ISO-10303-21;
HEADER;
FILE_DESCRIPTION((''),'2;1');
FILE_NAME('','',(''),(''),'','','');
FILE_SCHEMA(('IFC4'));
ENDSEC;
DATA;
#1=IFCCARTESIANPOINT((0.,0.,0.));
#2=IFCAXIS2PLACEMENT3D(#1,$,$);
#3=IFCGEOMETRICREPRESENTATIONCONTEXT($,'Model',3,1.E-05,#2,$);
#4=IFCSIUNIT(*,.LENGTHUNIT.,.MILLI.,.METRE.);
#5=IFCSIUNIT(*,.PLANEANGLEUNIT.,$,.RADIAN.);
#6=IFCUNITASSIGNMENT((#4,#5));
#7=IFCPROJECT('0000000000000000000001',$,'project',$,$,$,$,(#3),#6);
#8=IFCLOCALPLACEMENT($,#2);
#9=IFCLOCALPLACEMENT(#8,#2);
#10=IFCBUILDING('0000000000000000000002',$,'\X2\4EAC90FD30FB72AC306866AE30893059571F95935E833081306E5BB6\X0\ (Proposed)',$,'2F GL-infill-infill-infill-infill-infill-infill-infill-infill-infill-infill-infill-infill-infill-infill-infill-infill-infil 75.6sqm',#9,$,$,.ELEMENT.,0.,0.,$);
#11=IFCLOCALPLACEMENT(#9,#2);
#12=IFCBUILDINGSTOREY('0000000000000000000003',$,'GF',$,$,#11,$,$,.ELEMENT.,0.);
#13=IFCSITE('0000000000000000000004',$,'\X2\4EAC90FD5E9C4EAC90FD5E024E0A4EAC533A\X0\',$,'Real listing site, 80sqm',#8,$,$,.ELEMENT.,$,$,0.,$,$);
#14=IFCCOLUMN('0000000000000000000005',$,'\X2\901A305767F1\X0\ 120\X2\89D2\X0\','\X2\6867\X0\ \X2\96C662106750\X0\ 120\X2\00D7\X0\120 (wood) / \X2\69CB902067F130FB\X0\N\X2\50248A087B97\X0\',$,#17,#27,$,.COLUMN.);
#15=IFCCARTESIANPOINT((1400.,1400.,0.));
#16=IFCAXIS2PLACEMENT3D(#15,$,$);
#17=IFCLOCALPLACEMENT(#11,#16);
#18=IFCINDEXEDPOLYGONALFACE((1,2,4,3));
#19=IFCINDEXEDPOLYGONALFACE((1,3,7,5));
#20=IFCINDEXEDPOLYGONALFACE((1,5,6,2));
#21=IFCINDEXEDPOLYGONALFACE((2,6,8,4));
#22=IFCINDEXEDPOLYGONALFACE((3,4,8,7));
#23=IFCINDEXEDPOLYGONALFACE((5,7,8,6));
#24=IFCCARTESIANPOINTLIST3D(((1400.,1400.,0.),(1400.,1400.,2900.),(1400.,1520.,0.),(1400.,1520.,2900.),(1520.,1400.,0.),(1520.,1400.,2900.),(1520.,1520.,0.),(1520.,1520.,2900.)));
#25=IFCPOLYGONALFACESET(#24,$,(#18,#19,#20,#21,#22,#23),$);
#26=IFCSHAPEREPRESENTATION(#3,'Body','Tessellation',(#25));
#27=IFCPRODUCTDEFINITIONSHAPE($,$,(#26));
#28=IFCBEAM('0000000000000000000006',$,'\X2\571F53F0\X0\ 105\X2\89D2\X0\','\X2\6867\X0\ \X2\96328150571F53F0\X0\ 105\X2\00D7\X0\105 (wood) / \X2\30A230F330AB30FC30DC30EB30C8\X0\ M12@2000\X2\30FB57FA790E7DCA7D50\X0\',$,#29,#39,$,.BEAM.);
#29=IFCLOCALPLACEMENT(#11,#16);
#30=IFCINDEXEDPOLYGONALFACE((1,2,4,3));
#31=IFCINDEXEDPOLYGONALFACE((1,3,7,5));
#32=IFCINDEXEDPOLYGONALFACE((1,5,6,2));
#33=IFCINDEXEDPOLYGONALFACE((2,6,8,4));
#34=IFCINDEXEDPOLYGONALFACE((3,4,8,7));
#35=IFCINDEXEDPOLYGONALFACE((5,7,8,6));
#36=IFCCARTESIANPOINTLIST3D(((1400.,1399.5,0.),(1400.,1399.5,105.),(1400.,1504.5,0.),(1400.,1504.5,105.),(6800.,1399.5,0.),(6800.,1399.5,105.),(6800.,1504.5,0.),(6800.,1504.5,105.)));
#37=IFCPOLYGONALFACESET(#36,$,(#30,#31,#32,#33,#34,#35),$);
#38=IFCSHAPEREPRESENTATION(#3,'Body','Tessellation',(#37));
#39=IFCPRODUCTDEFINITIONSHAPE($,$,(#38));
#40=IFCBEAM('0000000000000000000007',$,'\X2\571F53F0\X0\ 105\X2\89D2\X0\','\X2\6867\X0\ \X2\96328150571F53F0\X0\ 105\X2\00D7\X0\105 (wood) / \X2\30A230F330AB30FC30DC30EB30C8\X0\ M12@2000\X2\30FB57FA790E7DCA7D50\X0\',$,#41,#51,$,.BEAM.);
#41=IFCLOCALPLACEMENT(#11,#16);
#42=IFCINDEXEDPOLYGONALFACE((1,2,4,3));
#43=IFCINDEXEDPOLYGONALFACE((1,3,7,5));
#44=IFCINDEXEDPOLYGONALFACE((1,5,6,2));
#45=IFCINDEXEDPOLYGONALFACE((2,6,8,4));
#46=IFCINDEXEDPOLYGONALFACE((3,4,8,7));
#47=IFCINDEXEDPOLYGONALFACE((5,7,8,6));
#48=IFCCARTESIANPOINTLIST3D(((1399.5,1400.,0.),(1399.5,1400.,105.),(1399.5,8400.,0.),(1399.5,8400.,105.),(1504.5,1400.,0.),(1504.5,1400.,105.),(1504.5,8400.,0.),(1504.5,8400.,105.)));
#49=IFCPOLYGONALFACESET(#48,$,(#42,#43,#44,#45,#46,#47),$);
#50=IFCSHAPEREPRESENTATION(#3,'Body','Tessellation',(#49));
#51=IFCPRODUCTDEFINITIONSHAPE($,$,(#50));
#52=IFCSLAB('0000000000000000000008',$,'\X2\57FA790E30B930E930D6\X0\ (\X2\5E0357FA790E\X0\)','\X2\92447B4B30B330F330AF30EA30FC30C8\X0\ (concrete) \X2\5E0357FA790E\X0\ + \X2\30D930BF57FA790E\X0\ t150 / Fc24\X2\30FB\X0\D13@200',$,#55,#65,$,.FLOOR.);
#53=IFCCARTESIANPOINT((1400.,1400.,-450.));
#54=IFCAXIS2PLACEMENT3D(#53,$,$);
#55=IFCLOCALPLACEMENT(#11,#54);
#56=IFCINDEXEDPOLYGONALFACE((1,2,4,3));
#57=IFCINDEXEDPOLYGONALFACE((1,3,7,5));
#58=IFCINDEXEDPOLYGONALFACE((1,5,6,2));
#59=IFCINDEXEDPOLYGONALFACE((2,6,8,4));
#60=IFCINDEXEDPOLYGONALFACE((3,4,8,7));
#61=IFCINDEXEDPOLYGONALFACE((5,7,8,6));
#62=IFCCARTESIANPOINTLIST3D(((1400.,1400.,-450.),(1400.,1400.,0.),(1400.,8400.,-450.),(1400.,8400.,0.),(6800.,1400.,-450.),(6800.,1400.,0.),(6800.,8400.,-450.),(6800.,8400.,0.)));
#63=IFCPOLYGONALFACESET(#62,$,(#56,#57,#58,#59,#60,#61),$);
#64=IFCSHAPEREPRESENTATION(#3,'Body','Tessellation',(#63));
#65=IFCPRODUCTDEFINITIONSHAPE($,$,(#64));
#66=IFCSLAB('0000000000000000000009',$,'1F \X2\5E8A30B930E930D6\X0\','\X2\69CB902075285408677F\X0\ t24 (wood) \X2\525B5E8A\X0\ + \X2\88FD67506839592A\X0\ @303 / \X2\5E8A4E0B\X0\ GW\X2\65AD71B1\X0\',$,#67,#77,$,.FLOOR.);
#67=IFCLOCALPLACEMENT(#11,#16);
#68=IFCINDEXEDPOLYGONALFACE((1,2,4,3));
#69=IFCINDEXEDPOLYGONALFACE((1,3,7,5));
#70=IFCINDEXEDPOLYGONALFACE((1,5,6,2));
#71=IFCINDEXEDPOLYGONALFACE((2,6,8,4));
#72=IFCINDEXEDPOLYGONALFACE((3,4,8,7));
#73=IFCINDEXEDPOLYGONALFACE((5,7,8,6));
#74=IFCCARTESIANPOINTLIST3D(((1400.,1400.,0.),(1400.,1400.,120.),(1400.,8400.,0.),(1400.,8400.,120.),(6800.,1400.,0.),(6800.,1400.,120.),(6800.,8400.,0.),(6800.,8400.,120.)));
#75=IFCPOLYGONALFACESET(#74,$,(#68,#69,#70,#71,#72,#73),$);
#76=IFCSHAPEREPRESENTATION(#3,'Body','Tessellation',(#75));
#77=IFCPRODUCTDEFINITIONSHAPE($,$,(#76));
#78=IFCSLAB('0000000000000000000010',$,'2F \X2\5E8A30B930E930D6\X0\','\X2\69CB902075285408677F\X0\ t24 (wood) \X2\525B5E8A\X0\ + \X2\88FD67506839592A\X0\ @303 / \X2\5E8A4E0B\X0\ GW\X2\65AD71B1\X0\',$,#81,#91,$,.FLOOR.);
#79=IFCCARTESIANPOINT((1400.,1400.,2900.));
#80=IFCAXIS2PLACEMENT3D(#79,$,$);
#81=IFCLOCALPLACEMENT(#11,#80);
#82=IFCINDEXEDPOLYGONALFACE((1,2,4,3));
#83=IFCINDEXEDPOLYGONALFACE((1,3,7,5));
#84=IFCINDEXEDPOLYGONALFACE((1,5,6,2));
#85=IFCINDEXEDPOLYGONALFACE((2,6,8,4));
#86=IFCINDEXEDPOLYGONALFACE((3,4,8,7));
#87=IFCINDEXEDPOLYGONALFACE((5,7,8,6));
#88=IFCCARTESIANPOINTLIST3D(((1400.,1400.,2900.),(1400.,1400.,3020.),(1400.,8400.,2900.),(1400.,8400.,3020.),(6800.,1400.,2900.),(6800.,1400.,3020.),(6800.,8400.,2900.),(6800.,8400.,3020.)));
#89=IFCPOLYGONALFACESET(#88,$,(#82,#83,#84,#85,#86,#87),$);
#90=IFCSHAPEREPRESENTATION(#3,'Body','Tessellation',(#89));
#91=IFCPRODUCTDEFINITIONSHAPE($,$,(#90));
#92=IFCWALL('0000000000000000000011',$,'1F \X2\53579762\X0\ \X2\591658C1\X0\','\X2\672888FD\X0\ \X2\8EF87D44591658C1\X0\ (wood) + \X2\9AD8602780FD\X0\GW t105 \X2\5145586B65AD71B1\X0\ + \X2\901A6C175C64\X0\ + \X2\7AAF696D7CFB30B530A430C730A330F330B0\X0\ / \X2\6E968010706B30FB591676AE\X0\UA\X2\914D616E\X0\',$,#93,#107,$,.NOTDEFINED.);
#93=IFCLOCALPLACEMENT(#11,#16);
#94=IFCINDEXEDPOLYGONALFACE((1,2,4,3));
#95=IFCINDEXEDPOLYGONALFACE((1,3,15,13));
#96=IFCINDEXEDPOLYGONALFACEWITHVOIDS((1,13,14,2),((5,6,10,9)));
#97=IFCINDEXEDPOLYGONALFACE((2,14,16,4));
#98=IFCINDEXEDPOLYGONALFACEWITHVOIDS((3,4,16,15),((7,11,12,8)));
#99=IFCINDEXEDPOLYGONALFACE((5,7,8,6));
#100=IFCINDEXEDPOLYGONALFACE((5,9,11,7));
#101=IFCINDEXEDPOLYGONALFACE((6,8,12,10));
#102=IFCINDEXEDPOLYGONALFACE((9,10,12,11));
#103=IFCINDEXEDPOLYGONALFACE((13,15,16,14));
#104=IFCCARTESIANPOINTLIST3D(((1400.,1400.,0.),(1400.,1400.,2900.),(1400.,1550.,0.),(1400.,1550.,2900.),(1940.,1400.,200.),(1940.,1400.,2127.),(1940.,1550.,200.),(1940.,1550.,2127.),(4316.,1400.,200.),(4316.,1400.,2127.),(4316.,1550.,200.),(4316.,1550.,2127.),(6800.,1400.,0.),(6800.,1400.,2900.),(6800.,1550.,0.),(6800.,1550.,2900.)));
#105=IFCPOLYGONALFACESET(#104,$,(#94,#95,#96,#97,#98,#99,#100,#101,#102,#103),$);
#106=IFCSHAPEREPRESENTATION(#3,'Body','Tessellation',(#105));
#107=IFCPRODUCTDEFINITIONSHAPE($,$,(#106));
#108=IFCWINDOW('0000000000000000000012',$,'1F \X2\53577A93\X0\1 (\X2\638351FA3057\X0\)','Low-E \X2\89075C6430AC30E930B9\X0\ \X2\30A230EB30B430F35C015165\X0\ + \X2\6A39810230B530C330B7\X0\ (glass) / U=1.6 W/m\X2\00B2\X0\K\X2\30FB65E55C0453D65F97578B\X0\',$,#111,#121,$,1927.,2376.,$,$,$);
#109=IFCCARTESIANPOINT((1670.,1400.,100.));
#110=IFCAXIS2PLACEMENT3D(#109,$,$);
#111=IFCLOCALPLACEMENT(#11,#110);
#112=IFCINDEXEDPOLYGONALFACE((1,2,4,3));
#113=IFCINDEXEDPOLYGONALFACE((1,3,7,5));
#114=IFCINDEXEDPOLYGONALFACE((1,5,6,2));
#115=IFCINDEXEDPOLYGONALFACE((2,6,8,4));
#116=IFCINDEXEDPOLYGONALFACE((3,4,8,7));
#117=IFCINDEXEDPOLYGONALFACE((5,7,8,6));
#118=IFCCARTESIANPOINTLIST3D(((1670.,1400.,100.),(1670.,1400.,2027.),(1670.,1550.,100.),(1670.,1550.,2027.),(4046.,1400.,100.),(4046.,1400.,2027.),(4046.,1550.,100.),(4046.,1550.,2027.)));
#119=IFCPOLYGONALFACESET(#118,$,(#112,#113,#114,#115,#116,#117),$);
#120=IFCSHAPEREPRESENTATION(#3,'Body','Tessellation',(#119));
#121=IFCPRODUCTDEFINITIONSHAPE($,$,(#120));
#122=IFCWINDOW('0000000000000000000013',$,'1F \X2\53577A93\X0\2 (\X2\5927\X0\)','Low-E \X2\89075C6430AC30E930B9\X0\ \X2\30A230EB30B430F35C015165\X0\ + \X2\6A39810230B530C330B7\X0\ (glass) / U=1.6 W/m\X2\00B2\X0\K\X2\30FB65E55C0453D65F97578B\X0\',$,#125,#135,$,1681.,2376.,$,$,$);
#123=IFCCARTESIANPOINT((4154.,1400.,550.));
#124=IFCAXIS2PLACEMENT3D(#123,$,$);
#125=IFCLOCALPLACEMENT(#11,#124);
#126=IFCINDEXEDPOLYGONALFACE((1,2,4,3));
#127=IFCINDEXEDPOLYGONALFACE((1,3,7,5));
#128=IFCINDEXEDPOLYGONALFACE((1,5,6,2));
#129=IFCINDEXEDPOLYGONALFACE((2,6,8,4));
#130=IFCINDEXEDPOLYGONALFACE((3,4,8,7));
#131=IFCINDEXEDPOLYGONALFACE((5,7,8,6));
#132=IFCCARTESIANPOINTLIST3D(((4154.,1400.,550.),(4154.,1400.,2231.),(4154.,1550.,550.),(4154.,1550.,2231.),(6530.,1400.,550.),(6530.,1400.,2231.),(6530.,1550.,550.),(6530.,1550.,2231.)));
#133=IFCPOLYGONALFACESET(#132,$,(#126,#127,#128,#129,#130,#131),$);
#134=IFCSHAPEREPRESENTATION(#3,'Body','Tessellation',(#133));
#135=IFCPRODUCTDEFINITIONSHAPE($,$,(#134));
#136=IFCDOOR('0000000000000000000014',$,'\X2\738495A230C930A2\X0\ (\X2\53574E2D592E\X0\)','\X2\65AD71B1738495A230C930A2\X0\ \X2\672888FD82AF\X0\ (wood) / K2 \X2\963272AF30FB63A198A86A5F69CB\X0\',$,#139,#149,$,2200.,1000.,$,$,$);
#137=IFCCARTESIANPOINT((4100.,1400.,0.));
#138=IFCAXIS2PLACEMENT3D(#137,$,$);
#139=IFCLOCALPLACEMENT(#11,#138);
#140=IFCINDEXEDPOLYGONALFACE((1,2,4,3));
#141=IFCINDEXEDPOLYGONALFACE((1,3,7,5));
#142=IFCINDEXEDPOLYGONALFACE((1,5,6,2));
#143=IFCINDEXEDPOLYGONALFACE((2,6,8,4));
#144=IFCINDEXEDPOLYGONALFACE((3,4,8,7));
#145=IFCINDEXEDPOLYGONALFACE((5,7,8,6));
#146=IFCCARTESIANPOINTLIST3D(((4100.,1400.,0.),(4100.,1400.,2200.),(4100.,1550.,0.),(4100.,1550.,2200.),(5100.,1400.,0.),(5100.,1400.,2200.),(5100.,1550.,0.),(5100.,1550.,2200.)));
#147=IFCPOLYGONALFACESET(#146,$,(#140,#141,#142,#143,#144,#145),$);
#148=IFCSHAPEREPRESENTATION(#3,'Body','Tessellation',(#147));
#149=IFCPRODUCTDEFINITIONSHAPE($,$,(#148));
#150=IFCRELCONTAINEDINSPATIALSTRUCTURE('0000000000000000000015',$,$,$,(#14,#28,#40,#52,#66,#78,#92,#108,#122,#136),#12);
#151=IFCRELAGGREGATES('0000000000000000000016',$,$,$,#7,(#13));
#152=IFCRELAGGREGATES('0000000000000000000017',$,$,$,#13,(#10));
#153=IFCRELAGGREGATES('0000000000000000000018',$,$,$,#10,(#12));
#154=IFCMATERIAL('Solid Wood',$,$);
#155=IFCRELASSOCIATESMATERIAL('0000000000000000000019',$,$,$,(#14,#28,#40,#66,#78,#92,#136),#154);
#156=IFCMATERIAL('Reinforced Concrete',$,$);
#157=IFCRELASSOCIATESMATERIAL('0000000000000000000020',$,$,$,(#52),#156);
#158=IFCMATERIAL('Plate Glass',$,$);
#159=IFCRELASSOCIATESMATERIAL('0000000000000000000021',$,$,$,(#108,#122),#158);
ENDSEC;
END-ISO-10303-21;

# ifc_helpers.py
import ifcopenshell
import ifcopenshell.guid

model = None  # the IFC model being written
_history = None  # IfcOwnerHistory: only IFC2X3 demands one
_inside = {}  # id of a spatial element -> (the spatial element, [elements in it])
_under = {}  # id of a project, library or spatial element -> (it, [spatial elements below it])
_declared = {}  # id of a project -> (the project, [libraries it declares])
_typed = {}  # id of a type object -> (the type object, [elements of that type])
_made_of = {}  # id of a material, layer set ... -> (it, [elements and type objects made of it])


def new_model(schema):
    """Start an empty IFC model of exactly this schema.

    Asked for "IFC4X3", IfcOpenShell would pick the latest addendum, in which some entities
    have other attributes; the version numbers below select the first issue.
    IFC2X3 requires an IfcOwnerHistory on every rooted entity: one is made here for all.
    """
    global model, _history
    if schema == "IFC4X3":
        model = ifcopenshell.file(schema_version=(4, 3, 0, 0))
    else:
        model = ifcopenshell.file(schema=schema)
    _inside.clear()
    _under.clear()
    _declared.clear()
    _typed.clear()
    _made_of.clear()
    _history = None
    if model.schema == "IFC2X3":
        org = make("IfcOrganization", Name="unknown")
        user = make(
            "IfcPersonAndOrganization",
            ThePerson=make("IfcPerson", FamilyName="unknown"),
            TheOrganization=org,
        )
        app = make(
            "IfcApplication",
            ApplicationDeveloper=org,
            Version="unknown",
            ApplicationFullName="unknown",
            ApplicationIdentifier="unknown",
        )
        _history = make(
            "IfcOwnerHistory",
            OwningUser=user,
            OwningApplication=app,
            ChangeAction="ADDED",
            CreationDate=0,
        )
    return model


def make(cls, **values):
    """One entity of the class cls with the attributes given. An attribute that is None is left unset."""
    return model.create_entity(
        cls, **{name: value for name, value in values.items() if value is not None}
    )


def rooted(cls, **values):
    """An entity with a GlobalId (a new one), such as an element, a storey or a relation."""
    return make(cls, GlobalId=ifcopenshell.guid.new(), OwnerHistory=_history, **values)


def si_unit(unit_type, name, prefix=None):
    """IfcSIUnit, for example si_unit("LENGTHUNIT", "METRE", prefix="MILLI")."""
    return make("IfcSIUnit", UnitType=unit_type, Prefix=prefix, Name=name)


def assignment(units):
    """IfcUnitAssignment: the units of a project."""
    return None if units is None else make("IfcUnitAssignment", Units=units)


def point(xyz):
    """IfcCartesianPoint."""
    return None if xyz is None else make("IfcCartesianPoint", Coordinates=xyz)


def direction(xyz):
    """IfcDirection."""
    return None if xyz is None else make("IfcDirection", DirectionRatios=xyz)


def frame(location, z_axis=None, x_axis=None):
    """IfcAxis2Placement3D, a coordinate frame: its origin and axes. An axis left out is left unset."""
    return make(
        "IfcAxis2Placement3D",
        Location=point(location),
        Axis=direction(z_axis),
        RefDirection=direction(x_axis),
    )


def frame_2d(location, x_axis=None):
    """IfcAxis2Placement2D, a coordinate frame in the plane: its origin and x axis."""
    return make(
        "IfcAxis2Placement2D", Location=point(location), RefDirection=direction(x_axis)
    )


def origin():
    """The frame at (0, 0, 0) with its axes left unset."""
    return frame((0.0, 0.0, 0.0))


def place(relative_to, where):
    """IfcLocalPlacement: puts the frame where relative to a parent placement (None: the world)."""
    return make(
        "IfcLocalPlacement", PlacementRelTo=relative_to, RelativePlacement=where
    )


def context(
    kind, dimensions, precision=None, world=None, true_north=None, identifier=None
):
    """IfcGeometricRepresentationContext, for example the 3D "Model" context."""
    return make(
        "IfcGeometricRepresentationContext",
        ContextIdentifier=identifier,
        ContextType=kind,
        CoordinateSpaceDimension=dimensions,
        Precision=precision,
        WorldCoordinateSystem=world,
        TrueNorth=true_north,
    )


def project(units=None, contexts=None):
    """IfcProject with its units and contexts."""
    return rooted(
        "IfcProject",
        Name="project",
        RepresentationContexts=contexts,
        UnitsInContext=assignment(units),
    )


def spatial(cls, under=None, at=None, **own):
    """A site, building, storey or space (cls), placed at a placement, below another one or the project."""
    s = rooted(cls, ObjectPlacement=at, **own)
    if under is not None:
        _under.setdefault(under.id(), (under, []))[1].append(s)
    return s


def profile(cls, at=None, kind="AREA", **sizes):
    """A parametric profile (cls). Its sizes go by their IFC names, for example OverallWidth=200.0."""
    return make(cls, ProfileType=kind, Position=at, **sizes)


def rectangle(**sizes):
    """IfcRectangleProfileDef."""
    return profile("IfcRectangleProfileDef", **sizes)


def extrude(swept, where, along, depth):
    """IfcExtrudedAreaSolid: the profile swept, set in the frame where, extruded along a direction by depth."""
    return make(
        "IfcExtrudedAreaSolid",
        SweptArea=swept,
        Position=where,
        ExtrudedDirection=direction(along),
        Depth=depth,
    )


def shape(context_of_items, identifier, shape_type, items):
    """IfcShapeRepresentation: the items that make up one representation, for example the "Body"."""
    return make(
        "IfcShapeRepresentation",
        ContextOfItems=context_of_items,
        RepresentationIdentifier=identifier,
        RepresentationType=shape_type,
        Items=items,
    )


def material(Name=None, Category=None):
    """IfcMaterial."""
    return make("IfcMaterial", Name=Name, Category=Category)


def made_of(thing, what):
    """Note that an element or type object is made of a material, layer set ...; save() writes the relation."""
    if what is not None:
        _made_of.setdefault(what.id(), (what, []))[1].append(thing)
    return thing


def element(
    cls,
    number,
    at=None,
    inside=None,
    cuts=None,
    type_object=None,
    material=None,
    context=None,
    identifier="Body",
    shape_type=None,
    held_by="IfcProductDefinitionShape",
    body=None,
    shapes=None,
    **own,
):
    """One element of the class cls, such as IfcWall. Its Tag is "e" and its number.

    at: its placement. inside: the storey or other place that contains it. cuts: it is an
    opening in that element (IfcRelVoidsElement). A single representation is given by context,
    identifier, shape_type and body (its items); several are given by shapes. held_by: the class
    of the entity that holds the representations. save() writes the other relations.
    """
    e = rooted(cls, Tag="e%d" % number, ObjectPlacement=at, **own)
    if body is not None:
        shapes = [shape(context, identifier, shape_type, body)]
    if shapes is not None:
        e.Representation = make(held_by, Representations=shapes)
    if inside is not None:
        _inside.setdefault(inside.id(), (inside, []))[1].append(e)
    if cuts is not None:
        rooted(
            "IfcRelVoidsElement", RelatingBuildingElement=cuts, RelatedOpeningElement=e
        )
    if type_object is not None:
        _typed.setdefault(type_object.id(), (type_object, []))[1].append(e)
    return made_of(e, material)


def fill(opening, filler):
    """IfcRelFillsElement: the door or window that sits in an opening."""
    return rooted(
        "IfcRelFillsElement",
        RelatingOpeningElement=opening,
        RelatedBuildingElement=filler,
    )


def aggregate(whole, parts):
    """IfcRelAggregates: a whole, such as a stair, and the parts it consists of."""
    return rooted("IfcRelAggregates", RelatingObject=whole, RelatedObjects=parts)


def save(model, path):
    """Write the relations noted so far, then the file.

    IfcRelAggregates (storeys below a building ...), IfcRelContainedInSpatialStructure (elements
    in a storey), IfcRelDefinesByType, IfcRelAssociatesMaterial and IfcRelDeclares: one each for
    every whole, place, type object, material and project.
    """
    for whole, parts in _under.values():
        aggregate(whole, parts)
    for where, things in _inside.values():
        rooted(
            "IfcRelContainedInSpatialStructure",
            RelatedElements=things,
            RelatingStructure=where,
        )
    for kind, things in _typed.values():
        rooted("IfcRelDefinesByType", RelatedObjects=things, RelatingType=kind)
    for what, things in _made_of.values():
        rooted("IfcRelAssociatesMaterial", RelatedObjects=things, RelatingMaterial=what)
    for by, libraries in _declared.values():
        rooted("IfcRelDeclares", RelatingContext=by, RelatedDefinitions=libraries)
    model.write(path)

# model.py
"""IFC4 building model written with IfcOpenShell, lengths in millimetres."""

from ifc_helpers import new_model, si_unit, frame, frame_2d, origin, place, context, project, spatial, rectangle, extrude, material, element, fill, save


model = new_model("IFC4")

# Units and contexts
model_context = context("Model", 3, precision=1e-05, world=origin())
ifc_project = project(units=[si_unit("LENGTHUNIT", "METRE", prefix="MILLI"), si_unit("PLANEANGLEUNIT", "RADIAN")], contexts=[model_context])

# Site, building, storey
site_placement = place(None, origin())
site = spatial("IfcSite", under=ifc_project, at=site_placement, Name="京都府京都市上京区", ObjectType="Real listing site, 80sqm", CompositionType="ELEMENT", RefElevation=0.0)
building_placement = place(site_placement, origin())
building = spatial("IfcBuilding", under=site, at=building_placement, Name="京都・犬と暮らす土間広めの家 (Proposed)", ObjectType="2F GL-infill-infill-infill-infill-infill-infill-infill-infill-infill-infill-infill-infill-infill-infill-infill-infill-infil 75.6sqm", CompositionType="ELEMENT", ElevationOfRefHeight=0.0, ElevationOfTerrain=0.0)
storey_placement = place(building_placement, origin())
storey = spatial("IfcBuildingStorey", under=building, at=storey_placement, Name="GF", CompositionType="ELEMENT", Elevation=0.0)

# Column
ifc_material_1 = material(Name="Solid Wood")
column_placement = place(storey_placement, frame((1400.0, 1400.0, 0.0)))
element("IfcColumn", 1, at=column_placement, inside=storey, material=ifc_material_1, Name="通し柱 120角", Description="桧 集成材 120×120 (wood) / 構造柱・N値計算", PredefinedType="COLUMN", context=model_context, shape_type="SweptSolid", body=[
    extrude(rectangle(XDim=120.0, YDim=120.0, at=frame_2d((60.0, 60.0))), frame((1400.0, 1400.0, 0.0)), (0.0, 0.0, 1.0), 2900.0),
])

# Beams
beam_1_placement = place(storey_placement, frame((1400.0, 1400.0, 0.0)))
element("IfcBeam", 2, at=beam_1_placement, inside=storey, material=ifc_material_1, Name="土台 105角", Description="桧 防腐土台 105×105 (wood) / アンカーボルト M12@2000・基礎緊結", PredefinedType="BEAM", context=model_context, shape_type="SweptSolid", body=[
    extrude(rectangle(XDim=5400.0, YDim=105.0, at=frame_2d((2700.0, 52.0))), frame((1400.0, 1400.0, 0.0)), (0.0, 0.0, 1.0), 105.0),
])
beam_2_placement = place(storey_placement, frame((1400.0, 1400.0, 0.0)))
element("IfcBeam", 3, at=beam_2_placement, inside=storey, material=ifc_material_1, Name="土台 105角", Description="桧 防腐土台 105×105 (wood) / アンカーボルト M12@2000・基礎緊結", PredefinedType="BEAM", context=model_context, shape_type="SweptSolid", body=[
    extrude(rectangle(XDim=105.0, YDim=7000.0, at=frame_2d((52.0, 3500.0))), frame((1400.0, 1400.0, 0.0)), (0.0, 0.0, 1.0), 105.0),
])

# Slabs
ifc_material_2 = material(Name="Reinforced Concrete")
slab_1_placement = place(storey_placement, frame((1400.0, 1400.0, -450.0)))
element("IfcSlab", 4, at=slab_1_placement, inside=storey, material=ifc_material_2, Name="基礎スラブ (布基礎)", Description="鉄筋コンクリート (concrete) 布基礎 + ベタ基礎 t150 / Fc24・D13@200", PredefinedType="FLOOR", context=model_context, shape_type="SweptSolid", body=[
    extrude(rectangle(XDim=5400.0, YDim=7000.0, at=frame_2d((2700.0, 3500.0))), frame((1400.0, 1400.0, -450.0)), (0.0, 0.0, 1.0), 450.0),
])
slab_2_placement = place(storey_placement, frame((1400.0, 1400.0, 0.0)))
element("IfcSlab", 5, at=slab_2_placement, inside=storey, material=ifc_material_1, Name="1F 床スラブ", Description="構造用合板 t24 (wood) 剛床 + 製材根太 @303 / 床下 GW断熱", PredefinedType="FLOOR", context=model_context, shape_type="SweptSolid", body=[
    extrude(rectangle(XDim=5400.0, YDim=7000.0, at=frame_2d((2700.0, 3500.0))), frame((1400.0, 1400.0, 0.0)), (0.0, 0.0, 1.0), 120.0),
])
slab_3_placement = place(storey_placement, frame((1400.0, 1400.0, 2900.0)))
element("IfcSlab", 6, at=slab_3_placement, inside=storey, material=ifc_material_1, Name="2F 床スラブ", Description="構造用合板 t24 (wood) 剛床 + 製材根太 @303 / 床下 GW断熱", PredefinedType="FLOOR", context=model_context, shape_type="SweptSolid", body=[
    extrude(rectangle(XDim=5400.0, YDim=7000.0, at=frame_2d((2700.0, 3500.0))), frame((1400.0, 1400.0, 2900.0)), (0.0, 0.0, 1.0), 120.0),
])

# Wall, openings, windows, door
wall_1_placement = place(storey_placement, frame((1400.0, 1400.0, 0.0)))
wall_1 = element("IfcWall", 7, at=wall_1_placement, inside=storey, material=ifc_material_1, Name="1F 南面 外壁", Description="木製 軸組外壁 (wood) + 高性能GW t105 充填断熱 + 通気層 + 窯業系サイディング / 準耐火・外皮UA配慮", PredefinedType="NOTDEFINED", context=model_context, shape_type="SweptSolid", body=[
    extrude(rectangle(XDim=5400.0, YDim=150.0, at=frame_2d((2700.0, 75.0))), frame((1400.0, 1400.0, 0.0)), (0.0, 0.0, 1.0), 2900.0),
])
opening_1_placement = place(storey_placement, frame((1670.0, 1400.0, 100.0)))
opening_1 = element("IfcOpeningElement", 8, at=opening_1_placement, cuts=wall_1, PredefinedType="NOTDEFINED", context=model_context, shape_type="SweptSolid", body=[
    extrude(rectangle(XDim=2376.0, YDim=150.0, at=frame_2d((1188.0, 75.0))), frame((1670.0, 1400.0, 100.0)), (0.0, 0.0, 1.0), 1927.0),
])
opening_2_placement = place(storey_placement, frame((4154.0, 1400.0, 550.0)))
opening_2 = element("IfcOpeningElement", 9, at=opening_2_placement, cuts=wall_1, PredefinedType="NOTDEFINED", context=model_context, shape_type="SweptSolid", body=[
    extrude(rectangle(XDim=2376.0, YDim=150.0, at=frame_2d((1188.0, 75.0))), frame((4154.0, 1400.0, 550.0)), (0.0, 0.0, 1.0), 1681.0),
])
opening_3_placement = place(storey_placement, frame((4100.0, 1400.0, 0.0)))
opening_3 = element("IfcOpeningElement", 10, at=opening_3_placement, cuts=wall_1, PredefinedType="NOTDEFINED", context=model_context, shape_type="SweptSolid", body=[
    extrude(rectangle(XDim=1000.0, YDim=150.0, at=frame_2d((500.0, 75.0))), frame((4100.0, 1400.0, 0.0)), (0.0, 0.0, 1.0), 2200.0),
])
ifc_material_3 = material(Name="Plate Glass")
window_1_placement = place(storey_placement, frame((1670.0, 1400.0, 100.0)))
window_1 = element("IfcWindow", 11, at=window_1_placement, inside=storey, material=ifc_material_3, Name="1F 南窓1 (掃出し)", Description="Low-E 複層ガラス アルゴン封入 + 樹脂サッシ (glass) / U=1.6 W/m²K・日射取得型", OverallHeight=1927.0, OverallWidth=2376.0, context=model_context, shape_type="SweptSolid", body=[
    extrude(rectangle(XDim=2376.0, YDim=150.0, at=frame_2d((1188.0, 75.0))), frame((1670.0, 1400.0, 100.0)), (0.0, 0.0, 1.0), 1927.0),
])
fill(opening_1, window_1)
window_2_placement = place(storey_placement, frame((4154.0, 1400.0, 550.0)))
window_2 = element("IfcWindow", 12, at=window_2_placement, inside=storey, material=ifc_material_3, Name="1F 南窓2 (大)", Description="Low-E 複層ガラス アルゴン封入 + 樹脂サッシ (glass) / U=1.6 W/m²K・日射取得型", OverallHeight=1681.0, OverallWidth=2376.0, context=model_context, shape_type="SweptSolid", body=[
    extrude(rectangle(XDim=2376.0, YDim=150.0, at=frame_2d((1188.0, 75.0))), frame((4154.0, 1400.0, 550.0)), (0.0, 0.0, 1.0), 1681.0),
])
fill(opening_2, window_2)
door_placement = place(storey_placement, frame((4100.0, 1400.0, 0.0)))
door = element("IfcDoor", 13, at=door_placement, inside=storey, material=ifc_material_1, Name="玄関ドア (南中央)", Description="断熱玄関ドア 木製芯 (wood) / K2 防犯・採風機構", OverallHeight=2200.0, OverallWidth=1000.0, context=model_context, shape_type="SweptSolid", body=[
    extrude(rectangle(XDim=1000.0, YDim=150.0, at=frame_2d((500.0, 75.0))), frame((4100.0, 1400.0, 0.0)), (0.0, 0.0, 1.0), 2200.0),
])
fill(opening_3, door)

save(model, "model.ifc")
